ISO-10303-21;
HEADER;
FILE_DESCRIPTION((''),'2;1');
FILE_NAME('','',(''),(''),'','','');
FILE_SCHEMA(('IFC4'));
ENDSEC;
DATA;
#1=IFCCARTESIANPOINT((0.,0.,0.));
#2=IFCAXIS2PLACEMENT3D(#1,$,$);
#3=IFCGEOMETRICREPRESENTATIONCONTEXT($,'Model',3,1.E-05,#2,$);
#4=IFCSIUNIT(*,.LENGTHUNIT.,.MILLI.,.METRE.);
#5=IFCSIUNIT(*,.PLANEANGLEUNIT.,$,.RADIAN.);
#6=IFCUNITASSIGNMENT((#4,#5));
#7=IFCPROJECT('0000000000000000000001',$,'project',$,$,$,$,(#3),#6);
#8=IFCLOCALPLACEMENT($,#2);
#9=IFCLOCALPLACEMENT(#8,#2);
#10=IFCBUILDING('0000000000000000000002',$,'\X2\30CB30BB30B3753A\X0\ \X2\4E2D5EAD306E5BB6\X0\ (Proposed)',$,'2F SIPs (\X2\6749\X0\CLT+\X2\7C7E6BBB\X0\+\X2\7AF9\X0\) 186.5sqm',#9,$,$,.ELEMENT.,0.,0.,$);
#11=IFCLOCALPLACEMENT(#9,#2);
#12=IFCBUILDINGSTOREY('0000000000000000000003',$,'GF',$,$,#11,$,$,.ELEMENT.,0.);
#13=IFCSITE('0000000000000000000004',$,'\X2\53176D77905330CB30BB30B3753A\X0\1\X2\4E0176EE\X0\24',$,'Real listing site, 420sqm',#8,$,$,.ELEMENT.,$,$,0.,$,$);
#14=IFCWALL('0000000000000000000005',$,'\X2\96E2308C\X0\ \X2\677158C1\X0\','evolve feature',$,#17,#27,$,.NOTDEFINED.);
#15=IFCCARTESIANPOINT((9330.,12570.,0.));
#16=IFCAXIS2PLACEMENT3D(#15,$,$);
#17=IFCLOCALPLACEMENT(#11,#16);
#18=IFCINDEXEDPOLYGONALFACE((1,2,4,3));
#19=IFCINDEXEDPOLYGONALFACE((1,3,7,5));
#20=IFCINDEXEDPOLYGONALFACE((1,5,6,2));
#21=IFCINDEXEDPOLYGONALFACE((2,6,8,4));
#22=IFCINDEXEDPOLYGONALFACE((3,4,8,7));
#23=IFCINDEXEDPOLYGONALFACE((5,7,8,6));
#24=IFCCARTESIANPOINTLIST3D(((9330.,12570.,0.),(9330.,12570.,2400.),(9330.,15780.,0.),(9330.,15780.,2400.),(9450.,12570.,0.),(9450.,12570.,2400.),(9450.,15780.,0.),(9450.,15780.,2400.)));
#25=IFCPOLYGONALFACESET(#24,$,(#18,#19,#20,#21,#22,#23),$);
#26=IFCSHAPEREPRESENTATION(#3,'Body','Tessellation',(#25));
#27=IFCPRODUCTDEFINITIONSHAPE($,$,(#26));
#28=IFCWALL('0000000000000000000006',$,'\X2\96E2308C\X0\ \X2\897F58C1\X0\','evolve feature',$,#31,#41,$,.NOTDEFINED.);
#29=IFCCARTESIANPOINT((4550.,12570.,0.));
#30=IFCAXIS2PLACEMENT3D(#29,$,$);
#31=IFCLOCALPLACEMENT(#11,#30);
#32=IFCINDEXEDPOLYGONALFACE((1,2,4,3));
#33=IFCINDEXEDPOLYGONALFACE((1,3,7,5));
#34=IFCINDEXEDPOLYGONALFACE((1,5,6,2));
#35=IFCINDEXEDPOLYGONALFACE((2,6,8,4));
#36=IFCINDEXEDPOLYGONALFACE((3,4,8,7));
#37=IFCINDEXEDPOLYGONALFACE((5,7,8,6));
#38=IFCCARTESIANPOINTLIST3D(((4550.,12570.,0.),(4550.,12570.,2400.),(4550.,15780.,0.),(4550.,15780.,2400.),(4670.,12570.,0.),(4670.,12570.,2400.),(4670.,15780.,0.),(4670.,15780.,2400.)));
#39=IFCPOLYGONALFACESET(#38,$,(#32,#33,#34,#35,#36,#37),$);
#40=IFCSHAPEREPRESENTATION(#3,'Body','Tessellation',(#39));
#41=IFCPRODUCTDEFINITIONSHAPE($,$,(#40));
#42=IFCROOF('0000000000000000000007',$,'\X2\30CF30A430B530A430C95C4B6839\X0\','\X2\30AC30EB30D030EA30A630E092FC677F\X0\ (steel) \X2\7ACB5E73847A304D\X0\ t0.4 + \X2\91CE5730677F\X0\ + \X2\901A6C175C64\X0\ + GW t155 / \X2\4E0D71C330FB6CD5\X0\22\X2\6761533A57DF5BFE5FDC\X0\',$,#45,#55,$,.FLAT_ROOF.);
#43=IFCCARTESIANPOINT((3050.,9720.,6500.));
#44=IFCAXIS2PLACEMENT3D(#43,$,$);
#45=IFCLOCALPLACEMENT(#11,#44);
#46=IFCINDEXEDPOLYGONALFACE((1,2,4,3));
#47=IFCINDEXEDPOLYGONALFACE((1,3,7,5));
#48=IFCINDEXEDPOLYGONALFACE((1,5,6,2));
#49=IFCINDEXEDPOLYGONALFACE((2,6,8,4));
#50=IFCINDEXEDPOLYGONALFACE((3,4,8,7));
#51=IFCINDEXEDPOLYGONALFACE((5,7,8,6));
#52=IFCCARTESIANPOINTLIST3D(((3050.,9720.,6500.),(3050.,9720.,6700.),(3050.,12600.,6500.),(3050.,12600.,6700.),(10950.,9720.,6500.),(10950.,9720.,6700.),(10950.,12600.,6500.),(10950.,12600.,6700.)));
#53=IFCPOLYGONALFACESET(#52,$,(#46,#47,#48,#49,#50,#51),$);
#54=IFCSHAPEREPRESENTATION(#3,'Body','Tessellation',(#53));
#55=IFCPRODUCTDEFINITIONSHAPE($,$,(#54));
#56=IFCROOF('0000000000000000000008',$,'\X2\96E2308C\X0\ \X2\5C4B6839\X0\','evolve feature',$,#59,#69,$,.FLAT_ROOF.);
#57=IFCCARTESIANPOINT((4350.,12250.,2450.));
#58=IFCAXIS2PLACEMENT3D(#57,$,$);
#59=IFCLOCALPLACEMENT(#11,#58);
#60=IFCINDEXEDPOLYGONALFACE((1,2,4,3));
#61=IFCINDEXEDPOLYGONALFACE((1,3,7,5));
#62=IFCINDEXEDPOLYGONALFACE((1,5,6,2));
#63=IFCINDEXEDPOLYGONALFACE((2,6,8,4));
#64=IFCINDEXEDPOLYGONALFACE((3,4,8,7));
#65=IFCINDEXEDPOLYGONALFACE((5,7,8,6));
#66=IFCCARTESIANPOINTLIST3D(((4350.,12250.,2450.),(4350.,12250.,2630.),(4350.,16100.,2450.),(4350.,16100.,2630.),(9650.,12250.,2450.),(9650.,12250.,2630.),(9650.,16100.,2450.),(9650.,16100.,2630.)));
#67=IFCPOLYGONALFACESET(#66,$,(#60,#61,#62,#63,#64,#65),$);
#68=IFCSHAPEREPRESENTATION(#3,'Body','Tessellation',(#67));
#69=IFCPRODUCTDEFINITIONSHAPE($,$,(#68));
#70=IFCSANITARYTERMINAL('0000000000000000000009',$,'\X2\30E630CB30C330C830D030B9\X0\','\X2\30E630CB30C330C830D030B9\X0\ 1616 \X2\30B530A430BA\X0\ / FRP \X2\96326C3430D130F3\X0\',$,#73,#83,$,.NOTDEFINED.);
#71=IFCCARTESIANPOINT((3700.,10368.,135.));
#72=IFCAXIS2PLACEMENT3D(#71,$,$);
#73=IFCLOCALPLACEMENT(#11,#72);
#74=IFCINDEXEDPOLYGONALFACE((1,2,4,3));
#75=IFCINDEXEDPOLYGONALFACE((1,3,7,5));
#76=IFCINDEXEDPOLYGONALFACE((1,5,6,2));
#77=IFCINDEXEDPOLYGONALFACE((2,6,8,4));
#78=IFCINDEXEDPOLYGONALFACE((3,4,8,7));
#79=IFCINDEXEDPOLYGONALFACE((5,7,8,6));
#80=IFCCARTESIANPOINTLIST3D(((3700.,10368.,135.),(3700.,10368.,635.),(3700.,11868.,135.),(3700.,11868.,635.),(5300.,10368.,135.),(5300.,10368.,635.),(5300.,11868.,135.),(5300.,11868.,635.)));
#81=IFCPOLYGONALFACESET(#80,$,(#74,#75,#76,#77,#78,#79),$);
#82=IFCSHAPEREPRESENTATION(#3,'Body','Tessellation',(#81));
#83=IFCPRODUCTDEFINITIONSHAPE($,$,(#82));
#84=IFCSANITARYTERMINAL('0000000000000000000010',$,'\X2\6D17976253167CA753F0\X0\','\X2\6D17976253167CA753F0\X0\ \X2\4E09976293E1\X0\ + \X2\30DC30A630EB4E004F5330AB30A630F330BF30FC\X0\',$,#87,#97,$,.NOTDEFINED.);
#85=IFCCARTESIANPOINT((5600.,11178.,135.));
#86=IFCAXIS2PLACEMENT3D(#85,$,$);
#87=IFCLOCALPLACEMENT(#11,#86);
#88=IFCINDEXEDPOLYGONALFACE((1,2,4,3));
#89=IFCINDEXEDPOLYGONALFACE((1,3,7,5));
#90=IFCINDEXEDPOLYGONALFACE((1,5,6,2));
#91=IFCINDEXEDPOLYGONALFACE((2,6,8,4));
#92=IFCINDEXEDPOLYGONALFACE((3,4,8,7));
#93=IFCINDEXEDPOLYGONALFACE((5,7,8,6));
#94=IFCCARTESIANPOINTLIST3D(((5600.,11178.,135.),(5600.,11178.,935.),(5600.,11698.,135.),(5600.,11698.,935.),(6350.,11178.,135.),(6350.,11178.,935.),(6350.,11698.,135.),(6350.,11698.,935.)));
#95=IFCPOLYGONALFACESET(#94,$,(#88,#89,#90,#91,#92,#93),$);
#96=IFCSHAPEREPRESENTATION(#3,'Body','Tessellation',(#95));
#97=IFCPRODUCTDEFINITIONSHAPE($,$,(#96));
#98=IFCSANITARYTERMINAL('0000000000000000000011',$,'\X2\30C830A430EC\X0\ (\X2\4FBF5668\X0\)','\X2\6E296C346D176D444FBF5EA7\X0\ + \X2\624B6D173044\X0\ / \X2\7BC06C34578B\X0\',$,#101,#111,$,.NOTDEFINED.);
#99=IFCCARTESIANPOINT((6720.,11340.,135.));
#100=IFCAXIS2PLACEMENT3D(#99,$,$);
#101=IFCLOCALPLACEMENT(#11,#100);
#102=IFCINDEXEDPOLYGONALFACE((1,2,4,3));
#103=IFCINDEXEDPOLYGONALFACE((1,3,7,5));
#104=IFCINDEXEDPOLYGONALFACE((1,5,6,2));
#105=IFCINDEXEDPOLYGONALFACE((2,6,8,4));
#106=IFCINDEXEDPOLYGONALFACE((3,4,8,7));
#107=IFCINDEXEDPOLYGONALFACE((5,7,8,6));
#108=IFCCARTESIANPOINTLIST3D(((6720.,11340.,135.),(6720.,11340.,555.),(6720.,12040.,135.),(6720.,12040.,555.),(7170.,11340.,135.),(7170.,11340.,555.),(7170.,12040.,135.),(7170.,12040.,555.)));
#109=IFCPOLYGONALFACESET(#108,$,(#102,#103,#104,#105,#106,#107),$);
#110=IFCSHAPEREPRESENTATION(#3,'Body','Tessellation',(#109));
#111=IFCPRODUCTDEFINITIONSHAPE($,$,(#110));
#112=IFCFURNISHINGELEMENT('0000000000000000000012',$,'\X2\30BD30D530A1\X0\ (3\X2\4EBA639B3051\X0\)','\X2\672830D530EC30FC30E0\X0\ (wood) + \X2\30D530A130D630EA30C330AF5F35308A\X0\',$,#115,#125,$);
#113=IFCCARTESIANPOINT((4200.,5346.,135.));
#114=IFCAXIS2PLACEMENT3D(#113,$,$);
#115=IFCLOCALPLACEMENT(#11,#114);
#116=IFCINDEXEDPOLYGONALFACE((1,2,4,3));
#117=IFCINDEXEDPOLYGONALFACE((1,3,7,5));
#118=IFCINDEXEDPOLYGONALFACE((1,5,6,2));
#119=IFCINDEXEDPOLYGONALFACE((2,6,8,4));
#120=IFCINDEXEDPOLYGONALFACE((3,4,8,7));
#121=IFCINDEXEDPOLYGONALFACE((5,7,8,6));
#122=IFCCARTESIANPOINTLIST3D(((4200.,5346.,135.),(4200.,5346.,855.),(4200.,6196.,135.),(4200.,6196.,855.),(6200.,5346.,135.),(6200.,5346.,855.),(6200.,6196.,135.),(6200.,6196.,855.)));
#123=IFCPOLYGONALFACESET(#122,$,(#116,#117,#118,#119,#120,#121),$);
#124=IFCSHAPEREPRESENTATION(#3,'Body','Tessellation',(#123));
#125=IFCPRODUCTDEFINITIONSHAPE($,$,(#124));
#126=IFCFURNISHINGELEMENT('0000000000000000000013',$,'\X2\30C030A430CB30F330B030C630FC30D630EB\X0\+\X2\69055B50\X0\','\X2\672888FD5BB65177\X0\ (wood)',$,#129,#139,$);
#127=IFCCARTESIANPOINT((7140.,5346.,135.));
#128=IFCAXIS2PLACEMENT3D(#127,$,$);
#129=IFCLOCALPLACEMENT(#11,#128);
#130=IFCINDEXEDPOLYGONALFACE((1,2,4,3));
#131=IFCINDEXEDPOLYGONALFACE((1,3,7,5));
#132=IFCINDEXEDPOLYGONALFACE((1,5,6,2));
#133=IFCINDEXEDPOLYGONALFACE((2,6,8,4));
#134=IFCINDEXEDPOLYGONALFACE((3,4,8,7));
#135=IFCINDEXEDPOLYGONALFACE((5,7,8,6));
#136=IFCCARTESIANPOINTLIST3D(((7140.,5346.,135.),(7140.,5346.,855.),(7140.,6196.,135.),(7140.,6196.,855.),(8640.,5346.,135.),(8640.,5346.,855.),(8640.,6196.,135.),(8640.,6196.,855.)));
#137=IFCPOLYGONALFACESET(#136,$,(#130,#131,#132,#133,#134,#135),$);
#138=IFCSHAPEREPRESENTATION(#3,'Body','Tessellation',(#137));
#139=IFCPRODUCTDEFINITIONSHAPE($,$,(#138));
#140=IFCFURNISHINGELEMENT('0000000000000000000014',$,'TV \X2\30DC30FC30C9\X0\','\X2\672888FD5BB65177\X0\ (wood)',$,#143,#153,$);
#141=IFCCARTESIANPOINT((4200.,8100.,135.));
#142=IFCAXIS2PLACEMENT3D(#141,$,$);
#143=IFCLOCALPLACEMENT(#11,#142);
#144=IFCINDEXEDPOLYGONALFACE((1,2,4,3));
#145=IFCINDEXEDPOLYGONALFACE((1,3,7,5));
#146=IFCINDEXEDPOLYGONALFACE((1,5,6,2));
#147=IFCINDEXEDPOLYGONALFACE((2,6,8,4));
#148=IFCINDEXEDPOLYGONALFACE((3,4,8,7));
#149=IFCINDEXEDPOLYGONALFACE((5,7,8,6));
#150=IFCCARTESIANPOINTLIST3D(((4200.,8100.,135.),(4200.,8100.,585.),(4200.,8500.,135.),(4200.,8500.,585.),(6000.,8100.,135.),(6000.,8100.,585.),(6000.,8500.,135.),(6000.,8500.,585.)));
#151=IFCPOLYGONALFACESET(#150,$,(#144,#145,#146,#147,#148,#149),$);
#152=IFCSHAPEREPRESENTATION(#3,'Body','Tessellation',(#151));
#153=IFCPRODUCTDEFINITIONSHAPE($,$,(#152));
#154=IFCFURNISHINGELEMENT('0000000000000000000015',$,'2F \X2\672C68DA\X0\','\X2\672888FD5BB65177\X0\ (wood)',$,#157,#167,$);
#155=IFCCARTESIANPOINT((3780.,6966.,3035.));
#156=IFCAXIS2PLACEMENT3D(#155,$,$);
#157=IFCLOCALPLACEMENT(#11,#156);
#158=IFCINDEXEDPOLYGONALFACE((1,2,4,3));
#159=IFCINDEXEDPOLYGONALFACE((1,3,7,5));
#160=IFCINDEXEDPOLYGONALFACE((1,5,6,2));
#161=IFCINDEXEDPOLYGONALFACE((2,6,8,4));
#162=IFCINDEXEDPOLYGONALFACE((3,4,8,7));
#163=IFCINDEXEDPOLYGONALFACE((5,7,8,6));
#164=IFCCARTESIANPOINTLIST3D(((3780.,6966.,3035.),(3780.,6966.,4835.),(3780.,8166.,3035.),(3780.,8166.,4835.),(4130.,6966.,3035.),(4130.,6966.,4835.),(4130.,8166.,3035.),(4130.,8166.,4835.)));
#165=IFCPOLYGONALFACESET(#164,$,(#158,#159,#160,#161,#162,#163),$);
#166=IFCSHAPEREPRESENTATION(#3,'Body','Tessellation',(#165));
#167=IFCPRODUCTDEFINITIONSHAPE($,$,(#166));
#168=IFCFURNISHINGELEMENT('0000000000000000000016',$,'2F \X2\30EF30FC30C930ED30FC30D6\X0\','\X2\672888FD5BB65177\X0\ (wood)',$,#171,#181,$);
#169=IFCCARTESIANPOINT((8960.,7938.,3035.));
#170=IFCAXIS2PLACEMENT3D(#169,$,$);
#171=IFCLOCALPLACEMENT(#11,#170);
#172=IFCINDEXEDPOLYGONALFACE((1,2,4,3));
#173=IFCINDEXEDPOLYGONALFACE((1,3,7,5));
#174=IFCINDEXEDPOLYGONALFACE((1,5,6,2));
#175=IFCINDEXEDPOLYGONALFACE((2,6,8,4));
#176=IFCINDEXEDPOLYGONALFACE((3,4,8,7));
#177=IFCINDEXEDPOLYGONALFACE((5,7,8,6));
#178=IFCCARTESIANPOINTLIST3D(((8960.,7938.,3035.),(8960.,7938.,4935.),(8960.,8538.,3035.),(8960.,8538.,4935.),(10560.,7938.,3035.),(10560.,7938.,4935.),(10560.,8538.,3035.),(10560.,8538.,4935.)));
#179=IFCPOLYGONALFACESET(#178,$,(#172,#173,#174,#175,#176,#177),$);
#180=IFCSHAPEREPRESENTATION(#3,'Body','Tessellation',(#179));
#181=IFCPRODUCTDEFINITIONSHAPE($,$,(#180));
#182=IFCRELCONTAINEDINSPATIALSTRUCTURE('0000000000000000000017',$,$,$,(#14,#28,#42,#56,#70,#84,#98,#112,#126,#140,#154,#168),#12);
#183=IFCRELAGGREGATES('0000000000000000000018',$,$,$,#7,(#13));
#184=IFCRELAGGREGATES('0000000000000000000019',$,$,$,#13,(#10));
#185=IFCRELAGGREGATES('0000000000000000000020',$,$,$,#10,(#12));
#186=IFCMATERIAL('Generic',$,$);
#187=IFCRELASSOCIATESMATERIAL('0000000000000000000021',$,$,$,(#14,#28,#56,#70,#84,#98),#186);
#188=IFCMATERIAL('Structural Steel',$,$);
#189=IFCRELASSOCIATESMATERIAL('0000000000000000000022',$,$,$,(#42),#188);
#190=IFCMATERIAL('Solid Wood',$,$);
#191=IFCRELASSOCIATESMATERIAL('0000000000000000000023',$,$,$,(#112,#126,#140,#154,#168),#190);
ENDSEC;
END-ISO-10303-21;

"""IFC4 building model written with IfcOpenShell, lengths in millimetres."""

from ifc_helpers import new_model, si_unit, frame, frame_2d, origin, place, context, project, spatial, rectangle, extrude, material, element, save


model = new_model("IFC4")

# Units and contexts
model_context = context("Model", 3, precision=1e-05, world=origin())
ifc_project = project(units=[si_unit("LENGTHUNIT", "METRE", prefix="MILLI"), si_unit("PLANEANGLEUNIT", "RADIAN")], contexts=[model_context])

# Site, building, storey
site_placement = place(None, origin())
site = spatial("IfcSite", under=ifc_project, at=site_placement, Name="北海道ニセコ町1丁目24", ObjectType="Real listing site, 420sqm", CompositionType="ELEMENT", RefElevation=0.0)
building_placement = place(site_placement, origin())
building = spatial("IfcBuilding", under=site, at=building_placement, Name="ニセコ町 中庭の家 (Proposed)", ObjectType="2F SIPs (杉CLT+籾殻+竹) 186.5sqm", CompositionType="ELEMENT", ElevationOfRefHeight=0.0, ElevationOfTerrain=0.0)
storey_placement = place(building_placement, origin())
storey = spatial("IfcBuildingStorey", under=building, at=storey_placement, Name="GF", CompositionType="ELEMENT", Elevation=0.0)

# Shared definitions
ifc_material_1 = material(Name="Generic")

# Shared definitions
ifc_material_2 = material(Name="Solid Wood")

# Walls
wall_1_placement = place(storey_placement, frame((9330.0, 12570.0, 0.0)))
element("IfcWall", 1, at=wall_1_placement, inside=storey, material=ifc_material_1, Name="離れ 東壁", Description="evolve feature", PredefinedType="NOTDEFINED", context=model_context, shape_type="SweptSolid", body=[
    extrude(rectangle(XDim=120.0, YDim=3210.0, at=frame_2d((60.0, 1605.0))), frame((9330.0, 12570.0, 0.0)), (0.0, 0.0, 1.0), 2400.0),
])
wall_2_placement = place(storey_placement, frame((4550.0, 12570.0, 0.0)))
element("IfcWall", 2, at=wall_2_placement, inside=storey, material=ifc_material_1, Name="離れ 西壁", Description="evolve feature", PredefinedType="NOTDEFINED", context=model_context, shape_type="SweptSolid", body=[
    extrude(rectangle(XDim=120.0, YDim=3210.0, at=frame_2d((60.0, 1605.0))), frame((4550.0, 12570.0, 0.0)), (0.0, 0.0, 1.0), 2400.0),
])

# Roofs
ifc_material_3 = material(Name="Structural Steel")
roof_1_placement = place(storey_placement, frame((3050.0, 9720.0, 6500.0)))
element("IfcRoof", 3, at=roof_1_placement, inside=storey, material=ifc_material_3, Name="ハイサイド屋根", Description="ガルバリウム鋼板 (steel) 立平葺き t0.4 + 野地板 + 通気層 + GW t155 / 不燃・法22条区域対応", PredefinedType="FLAT_ROOF", context=model_context, shape_type="SweptSolid", body=[
    extrude(rectangle(XDim=7900.0, YDim=2880.0, at=frame_2d((3950.0, 1440.0))), frame((3050.0, 9720.0, 6500.0)), (0.0, 0.0, 1.0), 200.0),
])
roof_2_placement = place(storey_placement, frame((4350.0, 12250.0, 2450.0)))
element("IfcRoof", 4, at=roof_2_placement, inside=storey, material=ifc_material_1, Name="離れ 屋根", Description="evolve feature", PredefinedType="FLAT_ROOF", context=model_context, shape_type="SweptSolid", body=[
    extrude(rectangle(XDim=5300.0, YDim=3850.0, at=frame_2d((2650.0, 1925.0))), frame((4350.0, 12250.0, 2450.0)), (0.0, 0.0, 1.0), 180.0),
])

# Sanitary terminals
sanitary_terminal_1_placement = place(storey_placement, frame((3700.0, 10368.0, 135.0)))
element("IfcSanitaryTerminal", 5, at=sanitary_terminal_1_placement, inside=storey, material=ifc_material_1, Name="ユニットバス", Description="ユニットバス 1616 サイズ / FRP 防水パン", PredefinedType="NOTDEFINED", context=model_context, shape_type="SweptSolid", body=[
    extrude(rectangle(XDim=1600.0, YDim=1500.0, at=frame_2d((800.0, 750.0))), frame((3700.0, 10368.0, 135.0)), (0.0, 0.0, 1.0), 500.0),
])
sanitary_terminal_2_placement = place(storey_placement, frame((5600.0, 11178.0, 135.0)))
element("IfcSanitaryTerminal", 6, at=sanitary_terminal_2_placement, inside=storey, material=ifc_material_1, Name="洗面化粧台", Description="洗面化粧台 三面鏡 + ボウル一体カウンター", PredefinedType="NOTDEFINED", context=model_context, shape_type="SweptSolid", body=[
    extrude(rectangle(XDim=750.0, YDim=520.0, at=frame_2d((375.0, 260.0))), frame((5600.0, 11178.0, 135.0)), (0.0, 0.0, 1.0), 800.0),
])
sanitary_terminal_3_placement = place(storey_placement, frame((6720.0, 11340.0, 135.0)))
element("IfcSanitaryTerminal", 7, at=sanitary_terminal_3_placement, inside=storey, material=ifc_material_1, Name="トイレ (便器)", Description="温水洗浄便座 + 手洗い / 節水型", PredefinedType="NOTDEFINED", context=model_context, shape_type="SweptSolid", body=[
    extrude(rectangle(XDim=450.0, YDim=700.0, at=frame_2d((225.0, 350.0))), frame((6720.0, 11340.0, 135.0)), (0.0, 0.0, 1.0), 420.0),
])

# Furnishing elements
furnishing_1_placement = place(storey_placement, frame((4200.0, 5346.0, 135.0)))
element("IfcFurnishingElement", 8, at=furnishing_1_placement, inside=storey, material=ifc_material_2, Name="ソファ (3人掛け)", Description="木フレーム (wood) + ファブリック張り", context=model_context, shape_type="SweptSolid", body=[
    extrude(rectangle(XDim=2000.0, YDim=850.0, at=frame_2d((1000.0, 425.0))), frame((4200.0, 5346.0, 135.0)), (0.0, 0.0, 1.0), 720.0),
])
furnishing_2_placement = place(storey_placement, frame((7140.0, 5346.0, 135.0)))
element("IfcFurnishingElement", 9, at=furnishing_2_placement, inside=storey, material=ifc_material_2, Name="ダイニングテーブル+椅子", Description="木製家具 (wood)", context=model_context, shape_type="SweptSolid", body=[
    extrude(rectangle(XDim=1500.0, YDim=850.0, at=frame_2d((750.0, 425.0))), frame((7140.0, 5346.0, 135.0)), (0.0, 0.0, 1.0), 720.0),
])
furnishing_3_placement = place(storey_placement, frame((4200.0, 8100.0, 135.0)))
element("IfcFurnishingElement", 10, at=furnishing_3_placement, inside=storey, material=ifc_material_2, Name="TV ボード", Description="木製家具 (wood)", context=model_context, shape_type="SweptSolid", body=[
    extrude(rectangle(XDim=1800.0, YDim=400.0, at=frame_2d((900.0, 200.0))), frame((4200.0, 8100.0, 135.0)), (0.0, 0.0, 1.0), 450.0),
])
furnishing_4_placement = place(storey_placement, frame((3780.0, 6966.0, 3035.0)))
element("IfcFurnishingElement", 11, at=furnishing_4_placement, inside=storey, material=ifc_material_2, Name="2F 本棚", Description="木製家具 (wood)", context=model_context, shape_type="SweptSolid", body=[
    extrude(rectangle(XDim=350.0, YDim=1200.0, at=frame_2d((175.0, 600.0))), frame((3780.0, 6966.0, 3035.0)), (0.0, 0.0, 1.0), 1800.0),
])
furnishing_5_placement = place(storey_placement, frame((8960.0, 7938.0, 3035.0)))
element("IfcFurnishingElement", 12, at=furnishing_5_placement, inside=storey, material=ifc_material_2, Name="2F ワードローブ", Description="木製家具 (wood)", context=model_context, shape_type="SweptSolid", body=[
    extrude(rectangle(XDim=1600.0, YDim=600.0, at=frame_2d((800.0, 300.0))), frame((8960.0, 7938.0, 3035.0)), (0.0, 0.0, 1.0), 1900.0),
])

save(model, "model.ifc")
